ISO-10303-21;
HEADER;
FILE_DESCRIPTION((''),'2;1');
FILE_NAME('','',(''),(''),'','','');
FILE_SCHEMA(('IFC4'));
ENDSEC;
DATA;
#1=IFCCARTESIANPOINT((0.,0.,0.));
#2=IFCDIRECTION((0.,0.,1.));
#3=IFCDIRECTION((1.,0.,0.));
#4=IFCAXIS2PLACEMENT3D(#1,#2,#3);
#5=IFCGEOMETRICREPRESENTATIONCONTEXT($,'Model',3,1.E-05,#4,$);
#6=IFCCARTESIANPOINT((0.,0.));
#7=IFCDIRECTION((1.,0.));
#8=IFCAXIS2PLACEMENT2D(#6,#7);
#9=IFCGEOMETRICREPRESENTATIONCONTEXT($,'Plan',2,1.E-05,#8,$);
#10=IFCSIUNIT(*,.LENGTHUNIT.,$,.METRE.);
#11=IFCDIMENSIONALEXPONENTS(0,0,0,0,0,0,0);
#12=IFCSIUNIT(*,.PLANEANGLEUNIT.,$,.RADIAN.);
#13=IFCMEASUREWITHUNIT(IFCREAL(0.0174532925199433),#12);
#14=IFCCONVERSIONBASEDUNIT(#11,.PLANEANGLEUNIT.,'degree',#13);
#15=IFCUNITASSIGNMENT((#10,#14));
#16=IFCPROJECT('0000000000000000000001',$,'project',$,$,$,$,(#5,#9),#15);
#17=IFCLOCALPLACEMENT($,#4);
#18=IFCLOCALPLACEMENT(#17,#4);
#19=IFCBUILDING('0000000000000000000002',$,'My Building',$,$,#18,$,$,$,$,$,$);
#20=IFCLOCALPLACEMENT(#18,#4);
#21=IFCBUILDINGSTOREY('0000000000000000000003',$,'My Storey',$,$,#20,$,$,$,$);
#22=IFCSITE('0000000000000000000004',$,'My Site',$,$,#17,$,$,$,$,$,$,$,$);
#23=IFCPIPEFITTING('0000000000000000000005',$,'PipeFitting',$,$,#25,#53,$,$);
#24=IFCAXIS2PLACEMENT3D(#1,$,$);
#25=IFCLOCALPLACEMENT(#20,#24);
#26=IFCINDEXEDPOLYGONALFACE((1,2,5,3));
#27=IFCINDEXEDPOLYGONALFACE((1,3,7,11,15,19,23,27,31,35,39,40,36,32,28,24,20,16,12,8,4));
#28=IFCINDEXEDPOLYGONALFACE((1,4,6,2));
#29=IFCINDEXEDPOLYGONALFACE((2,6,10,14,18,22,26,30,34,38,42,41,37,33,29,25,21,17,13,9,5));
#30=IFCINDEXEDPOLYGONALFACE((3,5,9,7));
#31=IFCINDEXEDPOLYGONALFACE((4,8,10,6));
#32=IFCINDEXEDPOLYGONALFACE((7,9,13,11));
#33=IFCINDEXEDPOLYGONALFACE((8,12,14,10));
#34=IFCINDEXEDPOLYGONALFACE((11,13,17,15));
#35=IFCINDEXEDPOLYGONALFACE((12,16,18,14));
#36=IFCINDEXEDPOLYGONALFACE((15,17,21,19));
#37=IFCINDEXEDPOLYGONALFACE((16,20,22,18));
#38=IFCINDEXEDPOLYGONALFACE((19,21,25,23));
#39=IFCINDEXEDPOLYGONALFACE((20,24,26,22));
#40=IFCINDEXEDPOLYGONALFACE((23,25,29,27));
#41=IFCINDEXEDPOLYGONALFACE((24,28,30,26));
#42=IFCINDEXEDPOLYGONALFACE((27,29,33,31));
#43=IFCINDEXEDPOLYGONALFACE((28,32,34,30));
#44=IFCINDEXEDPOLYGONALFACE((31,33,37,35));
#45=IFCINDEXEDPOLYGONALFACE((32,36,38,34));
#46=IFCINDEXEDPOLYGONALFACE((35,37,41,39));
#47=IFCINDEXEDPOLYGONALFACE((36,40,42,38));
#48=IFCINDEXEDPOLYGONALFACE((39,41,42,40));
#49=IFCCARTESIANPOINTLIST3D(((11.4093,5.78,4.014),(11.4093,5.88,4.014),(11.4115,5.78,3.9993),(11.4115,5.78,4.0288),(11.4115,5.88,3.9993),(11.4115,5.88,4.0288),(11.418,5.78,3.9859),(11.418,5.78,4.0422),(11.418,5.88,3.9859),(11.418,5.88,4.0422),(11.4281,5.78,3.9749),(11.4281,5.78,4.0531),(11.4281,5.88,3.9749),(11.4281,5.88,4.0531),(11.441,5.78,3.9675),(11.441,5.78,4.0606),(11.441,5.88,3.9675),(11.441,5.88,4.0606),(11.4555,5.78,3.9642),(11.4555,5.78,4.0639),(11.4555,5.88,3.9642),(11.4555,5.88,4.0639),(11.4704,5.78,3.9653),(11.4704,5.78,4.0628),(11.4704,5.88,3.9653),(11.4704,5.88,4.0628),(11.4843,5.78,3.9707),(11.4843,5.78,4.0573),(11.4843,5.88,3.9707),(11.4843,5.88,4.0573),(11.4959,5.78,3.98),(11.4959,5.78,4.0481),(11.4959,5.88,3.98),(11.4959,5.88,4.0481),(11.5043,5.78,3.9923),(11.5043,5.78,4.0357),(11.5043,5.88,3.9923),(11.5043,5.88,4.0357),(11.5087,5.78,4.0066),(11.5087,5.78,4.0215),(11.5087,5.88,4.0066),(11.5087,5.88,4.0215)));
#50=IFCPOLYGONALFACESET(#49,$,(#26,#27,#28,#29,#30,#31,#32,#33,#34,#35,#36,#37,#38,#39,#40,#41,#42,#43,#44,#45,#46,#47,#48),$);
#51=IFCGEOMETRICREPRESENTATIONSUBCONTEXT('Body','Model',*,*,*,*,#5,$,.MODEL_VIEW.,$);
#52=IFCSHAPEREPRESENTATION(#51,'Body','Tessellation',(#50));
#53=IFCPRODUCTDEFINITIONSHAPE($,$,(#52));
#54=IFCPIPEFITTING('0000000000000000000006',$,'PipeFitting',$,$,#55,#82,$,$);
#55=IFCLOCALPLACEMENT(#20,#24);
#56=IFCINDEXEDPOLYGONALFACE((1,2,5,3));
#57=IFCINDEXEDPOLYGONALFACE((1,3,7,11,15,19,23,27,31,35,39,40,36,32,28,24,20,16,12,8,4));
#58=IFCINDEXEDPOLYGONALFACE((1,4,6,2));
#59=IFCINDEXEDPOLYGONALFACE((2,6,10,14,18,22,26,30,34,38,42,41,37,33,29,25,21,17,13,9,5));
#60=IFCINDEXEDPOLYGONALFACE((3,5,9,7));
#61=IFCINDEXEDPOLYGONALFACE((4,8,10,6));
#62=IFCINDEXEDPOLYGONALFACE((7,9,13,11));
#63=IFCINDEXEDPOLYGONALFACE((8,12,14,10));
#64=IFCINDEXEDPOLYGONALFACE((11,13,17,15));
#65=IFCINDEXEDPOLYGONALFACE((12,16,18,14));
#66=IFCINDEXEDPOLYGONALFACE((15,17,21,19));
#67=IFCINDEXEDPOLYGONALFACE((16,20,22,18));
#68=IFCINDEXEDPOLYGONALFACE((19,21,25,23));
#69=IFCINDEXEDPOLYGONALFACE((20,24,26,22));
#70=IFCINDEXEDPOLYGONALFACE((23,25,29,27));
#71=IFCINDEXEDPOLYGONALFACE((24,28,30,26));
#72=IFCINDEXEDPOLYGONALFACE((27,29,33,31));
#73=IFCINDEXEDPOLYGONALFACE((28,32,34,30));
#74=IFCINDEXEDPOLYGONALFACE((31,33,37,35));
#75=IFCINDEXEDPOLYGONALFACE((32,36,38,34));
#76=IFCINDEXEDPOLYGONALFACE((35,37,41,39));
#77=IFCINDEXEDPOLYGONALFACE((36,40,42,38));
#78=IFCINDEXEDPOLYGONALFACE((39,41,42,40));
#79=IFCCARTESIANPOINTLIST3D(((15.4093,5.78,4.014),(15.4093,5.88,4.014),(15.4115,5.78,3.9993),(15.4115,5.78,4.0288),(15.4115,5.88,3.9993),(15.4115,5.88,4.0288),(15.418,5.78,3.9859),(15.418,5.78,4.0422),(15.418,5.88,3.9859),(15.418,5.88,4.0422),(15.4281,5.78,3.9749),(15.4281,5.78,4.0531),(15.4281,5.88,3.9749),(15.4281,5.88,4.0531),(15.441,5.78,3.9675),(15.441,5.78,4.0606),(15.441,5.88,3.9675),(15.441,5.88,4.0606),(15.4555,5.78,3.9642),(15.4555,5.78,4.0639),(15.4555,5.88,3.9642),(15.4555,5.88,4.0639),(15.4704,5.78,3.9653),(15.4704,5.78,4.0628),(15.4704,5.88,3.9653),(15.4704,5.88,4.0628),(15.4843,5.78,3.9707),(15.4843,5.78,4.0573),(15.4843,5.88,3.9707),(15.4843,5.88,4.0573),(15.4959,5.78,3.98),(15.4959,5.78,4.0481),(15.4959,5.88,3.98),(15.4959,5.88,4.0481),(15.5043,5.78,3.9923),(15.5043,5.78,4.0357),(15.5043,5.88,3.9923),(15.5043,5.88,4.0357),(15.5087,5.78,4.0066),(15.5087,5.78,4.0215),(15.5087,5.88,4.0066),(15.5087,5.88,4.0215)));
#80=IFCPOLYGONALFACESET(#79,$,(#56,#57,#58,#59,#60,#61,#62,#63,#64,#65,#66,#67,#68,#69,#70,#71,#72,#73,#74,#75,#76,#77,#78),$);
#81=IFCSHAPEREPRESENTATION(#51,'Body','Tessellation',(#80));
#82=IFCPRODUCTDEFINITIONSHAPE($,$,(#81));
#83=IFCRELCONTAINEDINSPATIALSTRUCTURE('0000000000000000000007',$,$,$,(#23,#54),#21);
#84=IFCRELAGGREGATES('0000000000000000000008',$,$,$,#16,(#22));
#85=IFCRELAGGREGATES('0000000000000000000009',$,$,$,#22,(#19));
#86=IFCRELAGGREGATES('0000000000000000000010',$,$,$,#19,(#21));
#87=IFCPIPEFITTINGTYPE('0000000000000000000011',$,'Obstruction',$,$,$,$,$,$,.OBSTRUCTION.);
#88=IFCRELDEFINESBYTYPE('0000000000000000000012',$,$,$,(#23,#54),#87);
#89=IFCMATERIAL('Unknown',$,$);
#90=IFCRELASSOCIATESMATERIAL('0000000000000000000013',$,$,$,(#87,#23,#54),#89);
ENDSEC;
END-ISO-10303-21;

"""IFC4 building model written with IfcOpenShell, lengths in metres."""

from ifc_helpers import new_model, entity, si_unit, converted_unit, frame, origin_with_axes, origin_2d_with_axis, place, context, subcontext, project, spatial, circle, extrude, material, material_profile, profile_set, profile_usage, type_object, element, save


model = new_model("IFC4")

# Units and contexts
model_context = context("Model", 3, precision=1e-05, world=origin_with_axes())
plan_context = context("Plan", 2, precision=1e-05, world=origin_2d_with_axis())
body_context_1 = subcontext(model_context, "Body", "Model", "MODEL_VIEW")
ifc_project = project(units=[si_unit("LENGTHUNIT", "METRE"), converted_unit("PLANEANGLEUNIT", "degree", entity("IfcReal", 0.0174532925199433), si_unit("PLANEANGLEUNIT", "RADIAN"), dimensions=[0, 0, 0, 0, 0, 0, 0])], contexts=[model_context, plan_context])

# Site, building, storey
site_placement = place(None, origin_with_axes())
site = spatial("IfcSite", under=ifc_project, at=site_placement, Name="My Site")
building_placement = place(site_placement, origin_with_axes())
building = spatial("IfcBuilding", under=site, at=building_placement, Name="My Building")
storey_placement = place(building_placement, origin_with_axes())
storey = spatial("IfcBuildingStorey", under=building, at=storey_placement, Name="My Storey")

# Shared definitions
ifc_material = material(Name="Unknown")

# Pipe fittings
ifc_material_profile_1 = material_profile(ifc_material, circle(Radius=0.05))
ifc_profile_set_1 = profile_set([ifc_material_profile_1])
ifc_profile_usage_1 = profile_usage(ifc_profile_set_1, cardinal=5)
pipe_fitting_type_1 = type_object("IfcPipeFittingType", Name="Obstruction", PredefinedType="OBSTRUCTION", material=ifc_profile_set_1)
pipe_fitting_1_placement = place(storey_placement, frame((11.4593, 5.78, 4.014), z_axis=(0.0, 1.0, 0.0), x_axis=(-1.0, 0.0, 0.0)))
element("IfcPipeFitting", 1, at=pipe_fitting_1_placement, inside=storey, type_object=pipe_fitting_type_1, material=ifc_profile_usage_1, Name="PipeFitting", context=body_context_1, shape_type="SweptSolid", body=[
    extrude(circle(Radius=0.05), origin_with_axes(), (0.0, 0.0, 1.0), 0.1),
])
ifc_profile_usage_2 = profile_usage(ifc_profile_set_1, cardinal=5)
pipe_fitting_2_placement = place(storey_placement, frame((15.4593, 5.78, 4.014), z_axis=(0.0, 1.0, 0.0), x_axis=(-1.0, 0.0, 0.0)))
element("IfcPipeFitting", 2, at=pipe_fitting_2_placement, inside=storey, type_object=pipe_fitting_type_1, material=ifc_profile_usage_2, Name="PipeFitting", context=body_context_1, shape_type="SweptSolid", body=[
    extrude(circle(Radius=0.05), origin_with_axes(), (0.0, 0.0, 1.0), 0.1),
])

save(model, "model.ifc")
